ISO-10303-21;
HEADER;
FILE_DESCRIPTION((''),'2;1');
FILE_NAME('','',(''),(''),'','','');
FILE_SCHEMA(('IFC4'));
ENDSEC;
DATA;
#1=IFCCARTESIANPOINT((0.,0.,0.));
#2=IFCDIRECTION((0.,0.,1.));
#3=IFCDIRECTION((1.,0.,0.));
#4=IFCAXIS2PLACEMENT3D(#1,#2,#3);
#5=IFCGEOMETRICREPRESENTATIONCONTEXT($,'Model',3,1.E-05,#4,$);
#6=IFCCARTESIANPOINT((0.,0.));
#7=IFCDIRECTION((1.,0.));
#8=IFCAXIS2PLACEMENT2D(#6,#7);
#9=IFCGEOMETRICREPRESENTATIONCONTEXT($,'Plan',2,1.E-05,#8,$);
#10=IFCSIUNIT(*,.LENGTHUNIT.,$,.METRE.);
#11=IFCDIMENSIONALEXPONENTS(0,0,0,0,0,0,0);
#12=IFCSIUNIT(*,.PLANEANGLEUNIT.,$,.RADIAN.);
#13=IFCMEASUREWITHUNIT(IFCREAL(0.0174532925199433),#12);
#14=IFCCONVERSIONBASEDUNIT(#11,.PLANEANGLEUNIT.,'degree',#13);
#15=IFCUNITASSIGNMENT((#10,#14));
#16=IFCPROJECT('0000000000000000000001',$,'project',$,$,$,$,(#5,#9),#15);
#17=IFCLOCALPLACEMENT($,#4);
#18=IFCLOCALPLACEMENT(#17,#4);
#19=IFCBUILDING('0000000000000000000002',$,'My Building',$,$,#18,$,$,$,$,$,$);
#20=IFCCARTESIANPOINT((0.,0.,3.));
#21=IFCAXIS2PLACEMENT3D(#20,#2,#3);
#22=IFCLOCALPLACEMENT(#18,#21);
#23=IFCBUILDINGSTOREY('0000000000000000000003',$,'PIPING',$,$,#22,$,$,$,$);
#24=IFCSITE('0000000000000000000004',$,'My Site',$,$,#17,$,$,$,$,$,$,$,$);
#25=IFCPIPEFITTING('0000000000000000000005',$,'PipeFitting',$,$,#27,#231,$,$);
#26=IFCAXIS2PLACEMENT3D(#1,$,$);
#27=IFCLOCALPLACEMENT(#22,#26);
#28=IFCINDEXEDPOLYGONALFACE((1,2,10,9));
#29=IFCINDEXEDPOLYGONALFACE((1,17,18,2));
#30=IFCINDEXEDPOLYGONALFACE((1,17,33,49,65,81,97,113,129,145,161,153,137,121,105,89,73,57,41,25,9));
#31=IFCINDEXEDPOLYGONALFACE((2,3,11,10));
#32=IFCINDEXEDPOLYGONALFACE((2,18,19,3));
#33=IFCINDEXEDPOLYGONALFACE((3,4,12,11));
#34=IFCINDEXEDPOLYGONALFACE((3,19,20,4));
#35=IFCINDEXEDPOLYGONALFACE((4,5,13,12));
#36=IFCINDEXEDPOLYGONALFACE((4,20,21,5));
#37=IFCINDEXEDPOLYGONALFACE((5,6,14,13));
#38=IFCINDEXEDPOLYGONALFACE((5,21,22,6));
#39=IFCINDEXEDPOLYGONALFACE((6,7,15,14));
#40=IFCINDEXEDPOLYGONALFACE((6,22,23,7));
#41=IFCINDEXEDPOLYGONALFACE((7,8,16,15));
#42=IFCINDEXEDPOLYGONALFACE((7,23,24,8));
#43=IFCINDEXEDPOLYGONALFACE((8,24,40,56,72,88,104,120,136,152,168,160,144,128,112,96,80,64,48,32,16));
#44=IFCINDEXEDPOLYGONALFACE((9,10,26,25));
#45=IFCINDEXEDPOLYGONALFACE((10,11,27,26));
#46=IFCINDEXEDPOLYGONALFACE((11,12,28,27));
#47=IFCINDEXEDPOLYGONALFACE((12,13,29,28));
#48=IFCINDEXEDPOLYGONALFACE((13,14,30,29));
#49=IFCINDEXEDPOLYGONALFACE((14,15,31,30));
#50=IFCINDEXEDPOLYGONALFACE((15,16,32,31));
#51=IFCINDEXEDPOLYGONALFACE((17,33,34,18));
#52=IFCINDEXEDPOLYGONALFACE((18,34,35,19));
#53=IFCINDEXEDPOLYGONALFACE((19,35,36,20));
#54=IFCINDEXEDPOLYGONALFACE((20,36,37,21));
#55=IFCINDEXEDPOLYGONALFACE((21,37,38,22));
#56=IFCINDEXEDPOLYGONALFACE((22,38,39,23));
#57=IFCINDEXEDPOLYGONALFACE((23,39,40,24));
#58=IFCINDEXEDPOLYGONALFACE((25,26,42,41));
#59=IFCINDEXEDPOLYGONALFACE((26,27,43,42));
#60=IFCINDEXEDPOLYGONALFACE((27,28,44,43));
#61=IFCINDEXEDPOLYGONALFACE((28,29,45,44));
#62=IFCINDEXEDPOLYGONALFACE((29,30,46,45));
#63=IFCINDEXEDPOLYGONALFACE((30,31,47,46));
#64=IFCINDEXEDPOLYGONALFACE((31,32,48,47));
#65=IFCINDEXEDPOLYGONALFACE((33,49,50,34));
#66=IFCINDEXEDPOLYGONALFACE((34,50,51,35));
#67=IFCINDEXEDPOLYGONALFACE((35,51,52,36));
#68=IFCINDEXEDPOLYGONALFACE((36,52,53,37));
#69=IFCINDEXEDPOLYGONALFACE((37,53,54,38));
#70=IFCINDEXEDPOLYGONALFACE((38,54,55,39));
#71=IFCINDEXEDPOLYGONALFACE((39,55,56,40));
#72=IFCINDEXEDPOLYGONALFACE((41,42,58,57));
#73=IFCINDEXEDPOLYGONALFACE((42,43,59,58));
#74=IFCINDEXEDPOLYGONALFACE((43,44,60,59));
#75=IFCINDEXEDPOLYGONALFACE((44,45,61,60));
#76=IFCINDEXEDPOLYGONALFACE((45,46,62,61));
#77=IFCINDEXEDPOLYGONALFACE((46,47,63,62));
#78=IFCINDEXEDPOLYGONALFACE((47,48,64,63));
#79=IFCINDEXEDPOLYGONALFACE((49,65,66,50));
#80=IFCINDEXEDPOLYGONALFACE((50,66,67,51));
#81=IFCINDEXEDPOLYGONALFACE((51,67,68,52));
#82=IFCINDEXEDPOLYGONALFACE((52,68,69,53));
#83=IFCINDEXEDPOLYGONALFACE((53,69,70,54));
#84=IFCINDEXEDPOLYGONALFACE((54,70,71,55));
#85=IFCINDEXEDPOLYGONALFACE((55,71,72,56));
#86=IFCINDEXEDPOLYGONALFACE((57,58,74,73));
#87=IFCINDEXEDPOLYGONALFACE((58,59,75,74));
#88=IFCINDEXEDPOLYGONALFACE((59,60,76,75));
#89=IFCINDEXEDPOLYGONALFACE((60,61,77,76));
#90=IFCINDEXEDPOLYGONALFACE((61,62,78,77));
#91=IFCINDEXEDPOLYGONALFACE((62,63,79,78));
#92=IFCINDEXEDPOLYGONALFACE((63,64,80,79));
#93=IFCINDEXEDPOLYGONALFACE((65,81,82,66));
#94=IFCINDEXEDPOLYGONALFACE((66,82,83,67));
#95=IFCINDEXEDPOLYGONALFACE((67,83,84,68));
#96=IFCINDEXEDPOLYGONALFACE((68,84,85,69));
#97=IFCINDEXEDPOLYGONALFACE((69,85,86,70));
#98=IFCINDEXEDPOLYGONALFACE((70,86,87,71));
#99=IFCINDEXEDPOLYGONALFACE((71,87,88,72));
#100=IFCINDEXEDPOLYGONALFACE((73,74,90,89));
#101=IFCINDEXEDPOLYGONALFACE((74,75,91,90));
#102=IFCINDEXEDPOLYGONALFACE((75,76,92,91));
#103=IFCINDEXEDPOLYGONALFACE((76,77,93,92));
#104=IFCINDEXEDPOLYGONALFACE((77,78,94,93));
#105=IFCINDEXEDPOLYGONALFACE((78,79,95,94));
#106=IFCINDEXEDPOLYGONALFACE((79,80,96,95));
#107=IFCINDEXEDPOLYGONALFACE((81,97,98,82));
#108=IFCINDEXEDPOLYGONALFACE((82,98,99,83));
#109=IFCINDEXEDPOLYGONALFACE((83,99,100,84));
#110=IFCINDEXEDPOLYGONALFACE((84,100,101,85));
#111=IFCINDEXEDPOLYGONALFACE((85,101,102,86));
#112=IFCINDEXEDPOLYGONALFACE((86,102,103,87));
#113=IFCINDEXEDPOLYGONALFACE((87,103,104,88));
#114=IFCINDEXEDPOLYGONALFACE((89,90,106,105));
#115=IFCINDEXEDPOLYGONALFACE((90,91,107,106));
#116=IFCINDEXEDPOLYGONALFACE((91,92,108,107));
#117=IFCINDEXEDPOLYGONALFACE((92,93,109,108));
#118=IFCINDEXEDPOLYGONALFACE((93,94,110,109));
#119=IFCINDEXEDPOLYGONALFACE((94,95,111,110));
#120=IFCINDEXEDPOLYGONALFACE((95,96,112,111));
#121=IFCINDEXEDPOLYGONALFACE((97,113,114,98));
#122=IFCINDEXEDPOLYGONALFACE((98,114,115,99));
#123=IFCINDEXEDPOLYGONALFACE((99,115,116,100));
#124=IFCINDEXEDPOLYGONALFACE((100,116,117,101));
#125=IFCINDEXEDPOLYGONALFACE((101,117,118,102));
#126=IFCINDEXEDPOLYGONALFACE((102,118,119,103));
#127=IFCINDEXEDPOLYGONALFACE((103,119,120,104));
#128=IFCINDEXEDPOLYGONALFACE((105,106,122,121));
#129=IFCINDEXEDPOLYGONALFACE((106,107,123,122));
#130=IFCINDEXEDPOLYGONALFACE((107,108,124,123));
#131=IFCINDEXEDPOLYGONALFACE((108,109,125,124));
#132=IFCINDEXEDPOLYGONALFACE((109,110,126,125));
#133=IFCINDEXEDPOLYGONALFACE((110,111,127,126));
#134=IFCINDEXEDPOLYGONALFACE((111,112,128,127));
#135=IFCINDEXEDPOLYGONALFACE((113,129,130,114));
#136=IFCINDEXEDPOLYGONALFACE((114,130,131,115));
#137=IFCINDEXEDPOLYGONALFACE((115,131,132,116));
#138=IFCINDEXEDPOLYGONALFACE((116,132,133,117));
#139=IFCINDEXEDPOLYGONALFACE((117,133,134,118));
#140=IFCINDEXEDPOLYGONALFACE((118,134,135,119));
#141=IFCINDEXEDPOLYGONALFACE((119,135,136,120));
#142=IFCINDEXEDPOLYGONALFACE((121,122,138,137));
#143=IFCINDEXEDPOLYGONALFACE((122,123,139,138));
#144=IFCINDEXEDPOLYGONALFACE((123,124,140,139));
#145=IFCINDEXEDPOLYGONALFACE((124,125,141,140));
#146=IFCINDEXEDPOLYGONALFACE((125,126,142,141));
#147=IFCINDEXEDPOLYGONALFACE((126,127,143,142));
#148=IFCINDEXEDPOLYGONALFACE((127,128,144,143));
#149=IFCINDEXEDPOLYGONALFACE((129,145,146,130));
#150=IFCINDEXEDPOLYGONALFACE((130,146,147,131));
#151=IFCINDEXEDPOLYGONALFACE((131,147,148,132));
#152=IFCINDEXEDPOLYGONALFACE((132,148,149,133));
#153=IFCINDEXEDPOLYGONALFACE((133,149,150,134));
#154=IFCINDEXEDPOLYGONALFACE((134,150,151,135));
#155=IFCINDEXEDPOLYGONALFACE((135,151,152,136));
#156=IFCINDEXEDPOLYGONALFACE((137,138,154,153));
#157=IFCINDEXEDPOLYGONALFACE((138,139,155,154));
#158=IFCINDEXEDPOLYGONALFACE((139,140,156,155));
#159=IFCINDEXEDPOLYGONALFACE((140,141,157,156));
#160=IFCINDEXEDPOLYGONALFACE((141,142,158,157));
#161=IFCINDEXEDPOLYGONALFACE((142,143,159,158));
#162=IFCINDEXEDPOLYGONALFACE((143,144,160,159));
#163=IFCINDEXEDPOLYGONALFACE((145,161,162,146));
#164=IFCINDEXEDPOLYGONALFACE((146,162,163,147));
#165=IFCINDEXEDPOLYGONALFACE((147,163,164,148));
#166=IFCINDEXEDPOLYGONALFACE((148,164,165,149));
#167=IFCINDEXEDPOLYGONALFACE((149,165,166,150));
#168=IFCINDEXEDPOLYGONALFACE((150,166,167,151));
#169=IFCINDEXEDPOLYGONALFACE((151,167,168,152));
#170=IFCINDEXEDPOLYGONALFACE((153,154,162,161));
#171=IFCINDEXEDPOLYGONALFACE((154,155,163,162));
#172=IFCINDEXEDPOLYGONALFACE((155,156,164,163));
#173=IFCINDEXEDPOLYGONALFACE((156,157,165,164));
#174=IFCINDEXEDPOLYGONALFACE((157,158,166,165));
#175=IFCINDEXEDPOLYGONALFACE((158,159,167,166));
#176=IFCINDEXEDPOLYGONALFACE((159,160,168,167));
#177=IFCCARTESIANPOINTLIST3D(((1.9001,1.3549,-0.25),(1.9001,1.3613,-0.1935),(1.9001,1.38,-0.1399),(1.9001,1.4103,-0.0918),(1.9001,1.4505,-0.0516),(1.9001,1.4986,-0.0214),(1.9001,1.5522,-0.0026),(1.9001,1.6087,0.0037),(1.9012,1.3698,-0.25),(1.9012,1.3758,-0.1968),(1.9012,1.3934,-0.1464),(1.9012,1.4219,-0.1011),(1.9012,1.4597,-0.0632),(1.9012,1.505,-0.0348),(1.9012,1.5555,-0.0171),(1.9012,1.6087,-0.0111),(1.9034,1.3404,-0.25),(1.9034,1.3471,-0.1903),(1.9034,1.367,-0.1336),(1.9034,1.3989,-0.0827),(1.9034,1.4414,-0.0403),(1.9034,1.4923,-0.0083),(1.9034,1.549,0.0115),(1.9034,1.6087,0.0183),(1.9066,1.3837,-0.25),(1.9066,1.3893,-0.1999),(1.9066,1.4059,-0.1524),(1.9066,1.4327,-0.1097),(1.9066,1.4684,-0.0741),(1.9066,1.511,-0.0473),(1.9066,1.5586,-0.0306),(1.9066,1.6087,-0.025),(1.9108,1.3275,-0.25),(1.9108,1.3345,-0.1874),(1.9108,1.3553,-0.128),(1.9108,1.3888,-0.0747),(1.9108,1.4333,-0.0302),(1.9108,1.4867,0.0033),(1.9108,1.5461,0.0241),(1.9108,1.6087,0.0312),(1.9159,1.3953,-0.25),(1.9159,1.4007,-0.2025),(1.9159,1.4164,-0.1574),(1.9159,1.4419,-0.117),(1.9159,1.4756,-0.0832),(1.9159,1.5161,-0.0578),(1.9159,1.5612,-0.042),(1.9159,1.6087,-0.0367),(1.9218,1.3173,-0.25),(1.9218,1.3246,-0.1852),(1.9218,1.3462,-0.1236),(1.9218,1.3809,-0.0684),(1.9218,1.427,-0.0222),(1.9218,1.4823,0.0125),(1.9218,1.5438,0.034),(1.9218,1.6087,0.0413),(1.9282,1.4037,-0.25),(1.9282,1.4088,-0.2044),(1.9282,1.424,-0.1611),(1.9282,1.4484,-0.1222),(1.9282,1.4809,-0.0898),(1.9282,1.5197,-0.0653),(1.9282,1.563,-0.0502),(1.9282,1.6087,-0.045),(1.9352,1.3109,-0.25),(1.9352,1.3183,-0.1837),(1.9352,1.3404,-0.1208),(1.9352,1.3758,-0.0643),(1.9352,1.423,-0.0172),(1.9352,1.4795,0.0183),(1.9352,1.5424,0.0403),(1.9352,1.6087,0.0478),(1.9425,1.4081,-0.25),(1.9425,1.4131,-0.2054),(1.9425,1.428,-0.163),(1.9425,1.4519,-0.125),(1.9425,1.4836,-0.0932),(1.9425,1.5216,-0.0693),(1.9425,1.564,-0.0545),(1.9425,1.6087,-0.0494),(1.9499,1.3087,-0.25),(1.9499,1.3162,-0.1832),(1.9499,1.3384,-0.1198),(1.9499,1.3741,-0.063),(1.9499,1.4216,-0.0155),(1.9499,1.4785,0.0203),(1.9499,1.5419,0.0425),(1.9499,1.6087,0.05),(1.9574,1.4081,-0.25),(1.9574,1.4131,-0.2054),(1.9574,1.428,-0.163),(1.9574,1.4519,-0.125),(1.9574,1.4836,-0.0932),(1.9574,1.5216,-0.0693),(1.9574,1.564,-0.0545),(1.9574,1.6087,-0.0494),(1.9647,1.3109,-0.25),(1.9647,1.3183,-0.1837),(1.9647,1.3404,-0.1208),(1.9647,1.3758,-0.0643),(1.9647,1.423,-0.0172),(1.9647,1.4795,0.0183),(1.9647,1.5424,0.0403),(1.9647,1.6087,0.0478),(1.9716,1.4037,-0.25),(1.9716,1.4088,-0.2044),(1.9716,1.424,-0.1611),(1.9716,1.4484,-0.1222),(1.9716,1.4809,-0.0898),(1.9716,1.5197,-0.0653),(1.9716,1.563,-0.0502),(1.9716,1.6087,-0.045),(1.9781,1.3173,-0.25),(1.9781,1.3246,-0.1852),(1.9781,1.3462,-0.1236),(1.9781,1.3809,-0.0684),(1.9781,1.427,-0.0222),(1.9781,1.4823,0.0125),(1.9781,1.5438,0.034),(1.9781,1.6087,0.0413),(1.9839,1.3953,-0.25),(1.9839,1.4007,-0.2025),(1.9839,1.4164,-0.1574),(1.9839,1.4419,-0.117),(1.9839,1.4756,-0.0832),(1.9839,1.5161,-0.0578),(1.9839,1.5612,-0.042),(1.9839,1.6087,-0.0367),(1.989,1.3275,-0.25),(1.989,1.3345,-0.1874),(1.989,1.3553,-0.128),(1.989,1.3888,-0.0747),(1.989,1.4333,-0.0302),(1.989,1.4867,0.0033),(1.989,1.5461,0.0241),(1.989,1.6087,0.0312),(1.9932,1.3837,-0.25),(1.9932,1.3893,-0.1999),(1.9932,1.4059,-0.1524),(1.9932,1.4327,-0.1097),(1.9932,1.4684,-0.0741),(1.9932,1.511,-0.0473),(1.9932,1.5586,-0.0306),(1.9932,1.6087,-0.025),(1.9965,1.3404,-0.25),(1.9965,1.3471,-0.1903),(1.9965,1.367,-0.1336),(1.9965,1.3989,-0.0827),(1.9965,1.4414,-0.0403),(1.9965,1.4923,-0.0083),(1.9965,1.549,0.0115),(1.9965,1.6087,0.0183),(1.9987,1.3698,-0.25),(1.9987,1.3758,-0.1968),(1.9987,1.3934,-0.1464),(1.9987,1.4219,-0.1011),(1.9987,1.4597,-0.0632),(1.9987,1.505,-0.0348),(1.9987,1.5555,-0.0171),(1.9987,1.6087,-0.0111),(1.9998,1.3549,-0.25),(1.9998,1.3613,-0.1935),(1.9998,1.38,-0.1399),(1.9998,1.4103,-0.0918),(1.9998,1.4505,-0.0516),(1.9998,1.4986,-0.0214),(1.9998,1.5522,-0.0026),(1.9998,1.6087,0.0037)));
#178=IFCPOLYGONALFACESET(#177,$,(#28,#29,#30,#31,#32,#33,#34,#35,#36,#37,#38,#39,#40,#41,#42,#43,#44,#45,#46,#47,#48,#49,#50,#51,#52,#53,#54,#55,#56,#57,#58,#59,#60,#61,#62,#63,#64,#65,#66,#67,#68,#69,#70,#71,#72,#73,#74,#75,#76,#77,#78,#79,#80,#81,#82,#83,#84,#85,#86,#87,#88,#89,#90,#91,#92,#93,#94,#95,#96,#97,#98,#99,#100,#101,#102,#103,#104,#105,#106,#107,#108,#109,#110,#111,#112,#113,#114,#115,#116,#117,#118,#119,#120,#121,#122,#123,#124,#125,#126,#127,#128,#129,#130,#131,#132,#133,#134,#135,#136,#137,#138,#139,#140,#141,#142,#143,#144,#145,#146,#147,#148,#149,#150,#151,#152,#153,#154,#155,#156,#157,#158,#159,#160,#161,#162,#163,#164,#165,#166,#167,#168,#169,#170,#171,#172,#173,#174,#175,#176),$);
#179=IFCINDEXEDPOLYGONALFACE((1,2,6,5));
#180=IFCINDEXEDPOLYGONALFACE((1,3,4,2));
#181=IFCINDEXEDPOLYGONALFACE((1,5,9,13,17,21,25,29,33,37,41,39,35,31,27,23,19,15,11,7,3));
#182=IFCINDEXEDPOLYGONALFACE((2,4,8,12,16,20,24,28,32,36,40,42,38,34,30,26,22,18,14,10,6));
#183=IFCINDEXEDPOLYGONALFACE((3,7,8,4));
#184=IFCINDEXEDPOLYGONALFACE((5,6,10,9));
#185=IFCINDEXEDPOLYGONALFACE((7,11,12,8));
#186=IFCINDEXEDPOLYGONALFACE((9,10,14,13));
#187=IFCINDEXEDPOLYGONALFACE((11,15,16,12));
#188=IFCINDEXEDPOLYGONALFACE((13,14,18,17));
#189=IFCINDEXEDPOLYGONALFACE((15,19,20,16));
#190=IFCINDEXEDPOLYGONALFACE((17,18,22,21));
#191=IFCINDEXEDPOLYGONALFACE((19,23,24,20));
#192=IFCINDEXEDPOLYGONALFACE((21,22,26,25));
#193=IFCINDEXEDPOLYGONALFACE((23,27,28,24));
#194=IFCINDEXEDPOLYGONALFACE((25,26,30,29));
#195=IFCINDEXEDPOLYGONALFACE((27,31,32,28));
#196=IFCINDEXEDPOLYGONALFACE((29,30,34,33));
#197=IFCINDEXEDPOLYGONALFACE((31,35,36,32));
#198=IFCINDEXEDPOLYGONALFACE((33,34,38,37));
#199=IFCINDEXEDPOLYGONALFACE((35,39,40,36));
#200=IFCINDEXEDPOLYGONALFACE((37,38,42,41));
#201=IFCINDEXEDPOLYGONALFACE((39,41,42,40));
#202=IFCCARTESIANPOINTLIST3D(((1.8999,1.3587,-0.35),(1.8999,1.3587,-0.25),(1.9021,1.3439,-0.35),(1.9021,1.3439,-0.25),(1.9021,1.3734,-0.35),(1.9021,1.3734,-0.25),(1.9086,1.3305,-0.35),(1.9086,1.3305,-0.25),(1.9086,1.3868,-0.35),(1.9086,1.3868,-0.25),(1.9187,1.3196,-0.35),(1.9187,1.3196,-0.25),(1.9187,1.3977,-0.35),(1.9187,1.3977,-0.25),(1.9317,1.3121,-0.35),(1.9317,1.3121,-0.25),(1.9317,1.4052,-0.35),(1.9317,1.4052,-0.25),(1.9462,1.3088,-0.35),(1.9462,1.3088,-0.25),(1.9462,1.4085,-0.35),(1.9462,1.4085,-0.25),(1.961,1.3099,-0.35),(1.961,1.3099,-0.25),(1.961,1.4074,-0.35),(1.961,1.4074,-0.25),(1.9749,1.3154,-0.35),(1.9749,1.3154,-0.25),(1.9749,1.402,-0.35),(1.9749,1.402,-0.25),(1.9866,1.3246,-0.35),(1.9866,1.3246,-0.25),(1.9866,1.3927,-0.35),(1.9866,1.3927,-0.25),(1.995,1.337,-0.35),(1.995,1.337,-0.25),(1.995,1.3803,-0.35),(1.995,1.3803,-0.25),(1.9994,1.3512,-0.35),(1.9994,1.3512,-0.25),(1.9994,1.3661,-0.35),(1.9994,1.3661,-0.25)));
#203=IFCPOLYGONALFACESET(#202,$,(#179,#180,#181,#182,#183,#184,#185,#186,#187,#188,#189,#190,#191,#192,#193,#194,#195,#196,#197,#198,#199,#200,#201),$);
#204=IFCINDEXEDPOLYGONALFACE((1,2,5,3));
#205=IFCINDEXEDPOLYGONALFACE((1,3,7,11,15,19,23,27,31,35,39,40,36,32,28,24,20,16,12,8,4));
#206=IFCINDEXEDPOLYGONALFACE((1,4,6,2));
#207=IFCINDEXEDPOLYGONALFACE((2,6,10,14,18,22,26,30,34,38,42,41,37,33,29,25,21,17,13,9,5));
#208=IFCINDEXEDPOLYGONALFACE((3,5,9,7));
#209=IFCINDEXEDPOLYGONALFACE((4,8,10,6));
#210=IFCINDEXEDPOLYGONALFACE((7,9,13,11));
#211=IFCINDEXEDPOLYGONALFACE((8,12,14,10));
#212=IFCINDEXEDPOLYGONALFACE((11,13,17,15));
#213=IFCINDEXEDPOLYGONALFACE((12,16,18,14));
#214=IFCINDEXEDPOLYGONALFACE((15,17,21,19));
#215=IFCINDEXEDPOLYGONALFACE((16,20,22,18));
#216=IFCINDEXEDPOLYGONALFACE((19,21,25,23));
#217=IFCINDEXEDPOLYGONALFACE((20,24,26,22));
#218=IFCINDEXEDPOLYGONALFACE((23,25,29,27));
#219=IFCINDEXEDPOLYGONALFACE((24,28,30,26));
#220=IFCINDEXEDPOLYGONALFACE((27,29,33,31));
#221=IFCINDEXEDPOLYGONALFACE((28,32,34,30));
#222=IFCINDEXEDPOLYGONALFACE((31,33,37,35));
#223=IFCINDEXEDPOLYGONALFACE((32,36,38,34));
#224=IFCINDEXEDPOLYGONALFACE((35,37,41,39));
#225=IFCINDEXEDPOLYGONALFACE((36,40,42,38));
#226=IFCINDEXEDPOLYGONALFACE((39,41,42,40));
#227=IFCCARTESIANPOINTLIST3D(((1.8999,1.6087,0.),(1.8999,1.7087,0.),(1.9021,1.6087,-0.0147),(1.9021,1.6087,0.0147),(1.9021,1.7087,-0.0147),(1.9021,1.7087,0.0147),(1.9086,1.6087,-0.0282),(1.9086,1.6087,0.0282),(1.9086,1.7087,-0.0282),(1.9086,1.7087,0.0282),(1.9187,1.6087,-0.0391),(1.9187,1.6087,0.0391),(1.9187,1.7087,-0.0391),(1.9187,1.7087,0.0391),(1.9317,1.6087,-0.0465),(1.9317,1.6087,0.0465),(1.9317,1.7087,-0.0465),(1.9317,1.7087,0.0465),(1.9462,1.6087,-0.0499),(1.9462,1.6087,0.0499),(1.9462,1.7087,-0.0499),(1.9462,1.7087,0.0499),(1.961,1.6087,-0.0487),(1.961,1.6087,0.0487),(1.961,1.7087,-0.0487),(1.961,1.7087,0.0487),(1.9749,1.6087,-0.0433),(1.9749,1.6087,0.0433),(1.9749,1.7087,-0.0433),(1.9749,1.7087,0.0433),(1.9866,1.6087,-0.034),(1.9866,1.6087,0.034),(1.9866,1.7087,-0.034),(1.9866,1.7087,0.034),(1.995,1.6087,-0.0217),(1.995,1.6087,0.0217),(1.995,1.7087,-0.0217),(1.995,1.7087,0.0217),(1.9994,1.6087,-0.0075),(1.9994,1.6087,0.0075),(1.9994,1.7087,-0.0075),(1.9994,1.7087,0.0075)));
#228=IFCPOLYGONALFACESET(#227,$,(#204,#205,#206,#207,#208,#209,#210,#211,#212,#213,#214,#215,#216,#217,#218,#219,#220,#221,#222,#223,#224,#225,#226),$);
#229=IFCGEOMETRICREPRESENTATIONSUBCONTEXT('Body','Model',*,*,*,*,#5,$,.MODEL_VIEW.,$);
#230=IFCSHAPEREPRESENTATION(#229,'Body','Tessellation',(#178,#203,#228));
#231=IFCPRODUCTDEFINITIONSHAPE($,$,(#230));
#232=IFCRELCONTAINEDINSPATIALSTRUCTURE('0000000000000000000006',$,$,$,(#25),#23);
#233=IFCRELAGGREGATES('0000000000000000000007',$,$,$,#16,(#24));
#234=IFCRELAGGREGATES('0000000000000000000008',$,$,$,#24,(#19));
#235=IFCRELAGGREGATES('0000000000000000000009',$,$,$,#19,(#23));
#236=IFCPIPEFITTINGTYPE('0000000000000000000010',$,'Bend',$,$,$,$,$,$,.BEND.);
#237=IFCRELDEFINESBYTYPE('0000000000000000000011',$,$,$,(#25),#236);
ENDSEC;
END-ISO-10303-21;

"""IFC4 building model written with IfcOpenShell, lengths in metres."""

from ifc_helpers import new_model, entity, si_unit, converted_unit, frame, origin_with_axes, origin_2d_with_axis, place, context, subcontext, project, spatial, circle, extrude, source, transform, mapped, type_object, type_shapes, element, save


model = new_model("IFC4")

# Units and contexts
model_context = context("Model", 3, precision=1e-05, world=origin_with_axes())
plan_context = context("Plan", 2, precision=1e-05, world=origin_2d_with_axis())
body_context = subcontext(model_context, "Body", "Model", "MODEL_VIEW")
ifc_project = project(units=[si_unit("LENGTHUNIT", "METRE"), converted_unit("PLANEANGLEUNIT", "degree", entity("IfcReal", 0.0174532925199433), si_unit("PLANEANGLEUNIT", "RADIAN"), dimensions=[0, 0, 0, 0, 0, 0, 0])], contexts=[model_context, plan_context])

# Site, building, storey
site_placement = place(None, origin_with_axes())
site = spatial("IfcSite", under=ifc_project, at=site_placement, Name="My Site")
building_placement = place(site_placement, origin_with_axes())
building = spatial("IfcBuilding", under=site, at=building_placement, Name="My Building")
storey_placement = place(building_placement, frame((0.0, 0.0, 3.0), z_axis=(0.0, 0.0, 1.0), x_axis=(1.0, 0.0, 0.0)))
storey = spatial("IfcBuildingStorey", under=building, at=storey_placement, Name="PIPING")

# Pipe fitting
pipe_fitting_type_1 = type_object("IfcPipeFittingType", Name="Bend", PredefinedType="BEND")
shared_shape = source(origin_with_axes(), body_context, "Body", "SolidModel", [
    entity("IfcSweptDiskSolid", entity("IfcIndexedPolyCurve", entity("IfcCartesianPointList3D", [[0.0, 0.0, -0.1], [0.0, 0.0732, -0.2768], [0.0, 0.25, -0.35]]), [entity("IfcArcIndex", [1, 2, 3])]), 0.05),
    extrude(circle(Radius=0.05), origin_with_axes(), (0.0, 0.0, -1.0), 0.1),
    extrude(circle(Radius=0.05), frame((0.0, 0.25, -0.35), z_axis=(0.0, 1.0, 0.0), x_axis=(1.0, 0.0, 0.0)), (0.0, 0.0, 1.0), 0.1),
])
type_shapes(pipe_fitting_type_1, [shared_shape])
for number, where, z_axis, x_axis, name in (
    (1, (1.9499, 1.3587, -0.35), (0.0, 0.0, -1.0), (-1.0, 0.0, 0.0), "PipeFitting"),
):
    element("IfcPipeFitting", number, at=place(storey_placement, frame(where, z_axis=z_axis, x_axis=x_axis)), inside=storey, type_object=pipe_fitting_type_1, Name=name, context=body_context, shape_type="MappedRepresentation", body=[
        mapped(shared_shape, transform((0.0, 0.0, 0.0), x_axis=(1.0, 0.0, 0.0), y_axis=(0.0, 1.0, 0.0), z_axis=(0.0, 0.0, 1.0), scale=1.0)),
    ])

save(model, "model.ifc")
